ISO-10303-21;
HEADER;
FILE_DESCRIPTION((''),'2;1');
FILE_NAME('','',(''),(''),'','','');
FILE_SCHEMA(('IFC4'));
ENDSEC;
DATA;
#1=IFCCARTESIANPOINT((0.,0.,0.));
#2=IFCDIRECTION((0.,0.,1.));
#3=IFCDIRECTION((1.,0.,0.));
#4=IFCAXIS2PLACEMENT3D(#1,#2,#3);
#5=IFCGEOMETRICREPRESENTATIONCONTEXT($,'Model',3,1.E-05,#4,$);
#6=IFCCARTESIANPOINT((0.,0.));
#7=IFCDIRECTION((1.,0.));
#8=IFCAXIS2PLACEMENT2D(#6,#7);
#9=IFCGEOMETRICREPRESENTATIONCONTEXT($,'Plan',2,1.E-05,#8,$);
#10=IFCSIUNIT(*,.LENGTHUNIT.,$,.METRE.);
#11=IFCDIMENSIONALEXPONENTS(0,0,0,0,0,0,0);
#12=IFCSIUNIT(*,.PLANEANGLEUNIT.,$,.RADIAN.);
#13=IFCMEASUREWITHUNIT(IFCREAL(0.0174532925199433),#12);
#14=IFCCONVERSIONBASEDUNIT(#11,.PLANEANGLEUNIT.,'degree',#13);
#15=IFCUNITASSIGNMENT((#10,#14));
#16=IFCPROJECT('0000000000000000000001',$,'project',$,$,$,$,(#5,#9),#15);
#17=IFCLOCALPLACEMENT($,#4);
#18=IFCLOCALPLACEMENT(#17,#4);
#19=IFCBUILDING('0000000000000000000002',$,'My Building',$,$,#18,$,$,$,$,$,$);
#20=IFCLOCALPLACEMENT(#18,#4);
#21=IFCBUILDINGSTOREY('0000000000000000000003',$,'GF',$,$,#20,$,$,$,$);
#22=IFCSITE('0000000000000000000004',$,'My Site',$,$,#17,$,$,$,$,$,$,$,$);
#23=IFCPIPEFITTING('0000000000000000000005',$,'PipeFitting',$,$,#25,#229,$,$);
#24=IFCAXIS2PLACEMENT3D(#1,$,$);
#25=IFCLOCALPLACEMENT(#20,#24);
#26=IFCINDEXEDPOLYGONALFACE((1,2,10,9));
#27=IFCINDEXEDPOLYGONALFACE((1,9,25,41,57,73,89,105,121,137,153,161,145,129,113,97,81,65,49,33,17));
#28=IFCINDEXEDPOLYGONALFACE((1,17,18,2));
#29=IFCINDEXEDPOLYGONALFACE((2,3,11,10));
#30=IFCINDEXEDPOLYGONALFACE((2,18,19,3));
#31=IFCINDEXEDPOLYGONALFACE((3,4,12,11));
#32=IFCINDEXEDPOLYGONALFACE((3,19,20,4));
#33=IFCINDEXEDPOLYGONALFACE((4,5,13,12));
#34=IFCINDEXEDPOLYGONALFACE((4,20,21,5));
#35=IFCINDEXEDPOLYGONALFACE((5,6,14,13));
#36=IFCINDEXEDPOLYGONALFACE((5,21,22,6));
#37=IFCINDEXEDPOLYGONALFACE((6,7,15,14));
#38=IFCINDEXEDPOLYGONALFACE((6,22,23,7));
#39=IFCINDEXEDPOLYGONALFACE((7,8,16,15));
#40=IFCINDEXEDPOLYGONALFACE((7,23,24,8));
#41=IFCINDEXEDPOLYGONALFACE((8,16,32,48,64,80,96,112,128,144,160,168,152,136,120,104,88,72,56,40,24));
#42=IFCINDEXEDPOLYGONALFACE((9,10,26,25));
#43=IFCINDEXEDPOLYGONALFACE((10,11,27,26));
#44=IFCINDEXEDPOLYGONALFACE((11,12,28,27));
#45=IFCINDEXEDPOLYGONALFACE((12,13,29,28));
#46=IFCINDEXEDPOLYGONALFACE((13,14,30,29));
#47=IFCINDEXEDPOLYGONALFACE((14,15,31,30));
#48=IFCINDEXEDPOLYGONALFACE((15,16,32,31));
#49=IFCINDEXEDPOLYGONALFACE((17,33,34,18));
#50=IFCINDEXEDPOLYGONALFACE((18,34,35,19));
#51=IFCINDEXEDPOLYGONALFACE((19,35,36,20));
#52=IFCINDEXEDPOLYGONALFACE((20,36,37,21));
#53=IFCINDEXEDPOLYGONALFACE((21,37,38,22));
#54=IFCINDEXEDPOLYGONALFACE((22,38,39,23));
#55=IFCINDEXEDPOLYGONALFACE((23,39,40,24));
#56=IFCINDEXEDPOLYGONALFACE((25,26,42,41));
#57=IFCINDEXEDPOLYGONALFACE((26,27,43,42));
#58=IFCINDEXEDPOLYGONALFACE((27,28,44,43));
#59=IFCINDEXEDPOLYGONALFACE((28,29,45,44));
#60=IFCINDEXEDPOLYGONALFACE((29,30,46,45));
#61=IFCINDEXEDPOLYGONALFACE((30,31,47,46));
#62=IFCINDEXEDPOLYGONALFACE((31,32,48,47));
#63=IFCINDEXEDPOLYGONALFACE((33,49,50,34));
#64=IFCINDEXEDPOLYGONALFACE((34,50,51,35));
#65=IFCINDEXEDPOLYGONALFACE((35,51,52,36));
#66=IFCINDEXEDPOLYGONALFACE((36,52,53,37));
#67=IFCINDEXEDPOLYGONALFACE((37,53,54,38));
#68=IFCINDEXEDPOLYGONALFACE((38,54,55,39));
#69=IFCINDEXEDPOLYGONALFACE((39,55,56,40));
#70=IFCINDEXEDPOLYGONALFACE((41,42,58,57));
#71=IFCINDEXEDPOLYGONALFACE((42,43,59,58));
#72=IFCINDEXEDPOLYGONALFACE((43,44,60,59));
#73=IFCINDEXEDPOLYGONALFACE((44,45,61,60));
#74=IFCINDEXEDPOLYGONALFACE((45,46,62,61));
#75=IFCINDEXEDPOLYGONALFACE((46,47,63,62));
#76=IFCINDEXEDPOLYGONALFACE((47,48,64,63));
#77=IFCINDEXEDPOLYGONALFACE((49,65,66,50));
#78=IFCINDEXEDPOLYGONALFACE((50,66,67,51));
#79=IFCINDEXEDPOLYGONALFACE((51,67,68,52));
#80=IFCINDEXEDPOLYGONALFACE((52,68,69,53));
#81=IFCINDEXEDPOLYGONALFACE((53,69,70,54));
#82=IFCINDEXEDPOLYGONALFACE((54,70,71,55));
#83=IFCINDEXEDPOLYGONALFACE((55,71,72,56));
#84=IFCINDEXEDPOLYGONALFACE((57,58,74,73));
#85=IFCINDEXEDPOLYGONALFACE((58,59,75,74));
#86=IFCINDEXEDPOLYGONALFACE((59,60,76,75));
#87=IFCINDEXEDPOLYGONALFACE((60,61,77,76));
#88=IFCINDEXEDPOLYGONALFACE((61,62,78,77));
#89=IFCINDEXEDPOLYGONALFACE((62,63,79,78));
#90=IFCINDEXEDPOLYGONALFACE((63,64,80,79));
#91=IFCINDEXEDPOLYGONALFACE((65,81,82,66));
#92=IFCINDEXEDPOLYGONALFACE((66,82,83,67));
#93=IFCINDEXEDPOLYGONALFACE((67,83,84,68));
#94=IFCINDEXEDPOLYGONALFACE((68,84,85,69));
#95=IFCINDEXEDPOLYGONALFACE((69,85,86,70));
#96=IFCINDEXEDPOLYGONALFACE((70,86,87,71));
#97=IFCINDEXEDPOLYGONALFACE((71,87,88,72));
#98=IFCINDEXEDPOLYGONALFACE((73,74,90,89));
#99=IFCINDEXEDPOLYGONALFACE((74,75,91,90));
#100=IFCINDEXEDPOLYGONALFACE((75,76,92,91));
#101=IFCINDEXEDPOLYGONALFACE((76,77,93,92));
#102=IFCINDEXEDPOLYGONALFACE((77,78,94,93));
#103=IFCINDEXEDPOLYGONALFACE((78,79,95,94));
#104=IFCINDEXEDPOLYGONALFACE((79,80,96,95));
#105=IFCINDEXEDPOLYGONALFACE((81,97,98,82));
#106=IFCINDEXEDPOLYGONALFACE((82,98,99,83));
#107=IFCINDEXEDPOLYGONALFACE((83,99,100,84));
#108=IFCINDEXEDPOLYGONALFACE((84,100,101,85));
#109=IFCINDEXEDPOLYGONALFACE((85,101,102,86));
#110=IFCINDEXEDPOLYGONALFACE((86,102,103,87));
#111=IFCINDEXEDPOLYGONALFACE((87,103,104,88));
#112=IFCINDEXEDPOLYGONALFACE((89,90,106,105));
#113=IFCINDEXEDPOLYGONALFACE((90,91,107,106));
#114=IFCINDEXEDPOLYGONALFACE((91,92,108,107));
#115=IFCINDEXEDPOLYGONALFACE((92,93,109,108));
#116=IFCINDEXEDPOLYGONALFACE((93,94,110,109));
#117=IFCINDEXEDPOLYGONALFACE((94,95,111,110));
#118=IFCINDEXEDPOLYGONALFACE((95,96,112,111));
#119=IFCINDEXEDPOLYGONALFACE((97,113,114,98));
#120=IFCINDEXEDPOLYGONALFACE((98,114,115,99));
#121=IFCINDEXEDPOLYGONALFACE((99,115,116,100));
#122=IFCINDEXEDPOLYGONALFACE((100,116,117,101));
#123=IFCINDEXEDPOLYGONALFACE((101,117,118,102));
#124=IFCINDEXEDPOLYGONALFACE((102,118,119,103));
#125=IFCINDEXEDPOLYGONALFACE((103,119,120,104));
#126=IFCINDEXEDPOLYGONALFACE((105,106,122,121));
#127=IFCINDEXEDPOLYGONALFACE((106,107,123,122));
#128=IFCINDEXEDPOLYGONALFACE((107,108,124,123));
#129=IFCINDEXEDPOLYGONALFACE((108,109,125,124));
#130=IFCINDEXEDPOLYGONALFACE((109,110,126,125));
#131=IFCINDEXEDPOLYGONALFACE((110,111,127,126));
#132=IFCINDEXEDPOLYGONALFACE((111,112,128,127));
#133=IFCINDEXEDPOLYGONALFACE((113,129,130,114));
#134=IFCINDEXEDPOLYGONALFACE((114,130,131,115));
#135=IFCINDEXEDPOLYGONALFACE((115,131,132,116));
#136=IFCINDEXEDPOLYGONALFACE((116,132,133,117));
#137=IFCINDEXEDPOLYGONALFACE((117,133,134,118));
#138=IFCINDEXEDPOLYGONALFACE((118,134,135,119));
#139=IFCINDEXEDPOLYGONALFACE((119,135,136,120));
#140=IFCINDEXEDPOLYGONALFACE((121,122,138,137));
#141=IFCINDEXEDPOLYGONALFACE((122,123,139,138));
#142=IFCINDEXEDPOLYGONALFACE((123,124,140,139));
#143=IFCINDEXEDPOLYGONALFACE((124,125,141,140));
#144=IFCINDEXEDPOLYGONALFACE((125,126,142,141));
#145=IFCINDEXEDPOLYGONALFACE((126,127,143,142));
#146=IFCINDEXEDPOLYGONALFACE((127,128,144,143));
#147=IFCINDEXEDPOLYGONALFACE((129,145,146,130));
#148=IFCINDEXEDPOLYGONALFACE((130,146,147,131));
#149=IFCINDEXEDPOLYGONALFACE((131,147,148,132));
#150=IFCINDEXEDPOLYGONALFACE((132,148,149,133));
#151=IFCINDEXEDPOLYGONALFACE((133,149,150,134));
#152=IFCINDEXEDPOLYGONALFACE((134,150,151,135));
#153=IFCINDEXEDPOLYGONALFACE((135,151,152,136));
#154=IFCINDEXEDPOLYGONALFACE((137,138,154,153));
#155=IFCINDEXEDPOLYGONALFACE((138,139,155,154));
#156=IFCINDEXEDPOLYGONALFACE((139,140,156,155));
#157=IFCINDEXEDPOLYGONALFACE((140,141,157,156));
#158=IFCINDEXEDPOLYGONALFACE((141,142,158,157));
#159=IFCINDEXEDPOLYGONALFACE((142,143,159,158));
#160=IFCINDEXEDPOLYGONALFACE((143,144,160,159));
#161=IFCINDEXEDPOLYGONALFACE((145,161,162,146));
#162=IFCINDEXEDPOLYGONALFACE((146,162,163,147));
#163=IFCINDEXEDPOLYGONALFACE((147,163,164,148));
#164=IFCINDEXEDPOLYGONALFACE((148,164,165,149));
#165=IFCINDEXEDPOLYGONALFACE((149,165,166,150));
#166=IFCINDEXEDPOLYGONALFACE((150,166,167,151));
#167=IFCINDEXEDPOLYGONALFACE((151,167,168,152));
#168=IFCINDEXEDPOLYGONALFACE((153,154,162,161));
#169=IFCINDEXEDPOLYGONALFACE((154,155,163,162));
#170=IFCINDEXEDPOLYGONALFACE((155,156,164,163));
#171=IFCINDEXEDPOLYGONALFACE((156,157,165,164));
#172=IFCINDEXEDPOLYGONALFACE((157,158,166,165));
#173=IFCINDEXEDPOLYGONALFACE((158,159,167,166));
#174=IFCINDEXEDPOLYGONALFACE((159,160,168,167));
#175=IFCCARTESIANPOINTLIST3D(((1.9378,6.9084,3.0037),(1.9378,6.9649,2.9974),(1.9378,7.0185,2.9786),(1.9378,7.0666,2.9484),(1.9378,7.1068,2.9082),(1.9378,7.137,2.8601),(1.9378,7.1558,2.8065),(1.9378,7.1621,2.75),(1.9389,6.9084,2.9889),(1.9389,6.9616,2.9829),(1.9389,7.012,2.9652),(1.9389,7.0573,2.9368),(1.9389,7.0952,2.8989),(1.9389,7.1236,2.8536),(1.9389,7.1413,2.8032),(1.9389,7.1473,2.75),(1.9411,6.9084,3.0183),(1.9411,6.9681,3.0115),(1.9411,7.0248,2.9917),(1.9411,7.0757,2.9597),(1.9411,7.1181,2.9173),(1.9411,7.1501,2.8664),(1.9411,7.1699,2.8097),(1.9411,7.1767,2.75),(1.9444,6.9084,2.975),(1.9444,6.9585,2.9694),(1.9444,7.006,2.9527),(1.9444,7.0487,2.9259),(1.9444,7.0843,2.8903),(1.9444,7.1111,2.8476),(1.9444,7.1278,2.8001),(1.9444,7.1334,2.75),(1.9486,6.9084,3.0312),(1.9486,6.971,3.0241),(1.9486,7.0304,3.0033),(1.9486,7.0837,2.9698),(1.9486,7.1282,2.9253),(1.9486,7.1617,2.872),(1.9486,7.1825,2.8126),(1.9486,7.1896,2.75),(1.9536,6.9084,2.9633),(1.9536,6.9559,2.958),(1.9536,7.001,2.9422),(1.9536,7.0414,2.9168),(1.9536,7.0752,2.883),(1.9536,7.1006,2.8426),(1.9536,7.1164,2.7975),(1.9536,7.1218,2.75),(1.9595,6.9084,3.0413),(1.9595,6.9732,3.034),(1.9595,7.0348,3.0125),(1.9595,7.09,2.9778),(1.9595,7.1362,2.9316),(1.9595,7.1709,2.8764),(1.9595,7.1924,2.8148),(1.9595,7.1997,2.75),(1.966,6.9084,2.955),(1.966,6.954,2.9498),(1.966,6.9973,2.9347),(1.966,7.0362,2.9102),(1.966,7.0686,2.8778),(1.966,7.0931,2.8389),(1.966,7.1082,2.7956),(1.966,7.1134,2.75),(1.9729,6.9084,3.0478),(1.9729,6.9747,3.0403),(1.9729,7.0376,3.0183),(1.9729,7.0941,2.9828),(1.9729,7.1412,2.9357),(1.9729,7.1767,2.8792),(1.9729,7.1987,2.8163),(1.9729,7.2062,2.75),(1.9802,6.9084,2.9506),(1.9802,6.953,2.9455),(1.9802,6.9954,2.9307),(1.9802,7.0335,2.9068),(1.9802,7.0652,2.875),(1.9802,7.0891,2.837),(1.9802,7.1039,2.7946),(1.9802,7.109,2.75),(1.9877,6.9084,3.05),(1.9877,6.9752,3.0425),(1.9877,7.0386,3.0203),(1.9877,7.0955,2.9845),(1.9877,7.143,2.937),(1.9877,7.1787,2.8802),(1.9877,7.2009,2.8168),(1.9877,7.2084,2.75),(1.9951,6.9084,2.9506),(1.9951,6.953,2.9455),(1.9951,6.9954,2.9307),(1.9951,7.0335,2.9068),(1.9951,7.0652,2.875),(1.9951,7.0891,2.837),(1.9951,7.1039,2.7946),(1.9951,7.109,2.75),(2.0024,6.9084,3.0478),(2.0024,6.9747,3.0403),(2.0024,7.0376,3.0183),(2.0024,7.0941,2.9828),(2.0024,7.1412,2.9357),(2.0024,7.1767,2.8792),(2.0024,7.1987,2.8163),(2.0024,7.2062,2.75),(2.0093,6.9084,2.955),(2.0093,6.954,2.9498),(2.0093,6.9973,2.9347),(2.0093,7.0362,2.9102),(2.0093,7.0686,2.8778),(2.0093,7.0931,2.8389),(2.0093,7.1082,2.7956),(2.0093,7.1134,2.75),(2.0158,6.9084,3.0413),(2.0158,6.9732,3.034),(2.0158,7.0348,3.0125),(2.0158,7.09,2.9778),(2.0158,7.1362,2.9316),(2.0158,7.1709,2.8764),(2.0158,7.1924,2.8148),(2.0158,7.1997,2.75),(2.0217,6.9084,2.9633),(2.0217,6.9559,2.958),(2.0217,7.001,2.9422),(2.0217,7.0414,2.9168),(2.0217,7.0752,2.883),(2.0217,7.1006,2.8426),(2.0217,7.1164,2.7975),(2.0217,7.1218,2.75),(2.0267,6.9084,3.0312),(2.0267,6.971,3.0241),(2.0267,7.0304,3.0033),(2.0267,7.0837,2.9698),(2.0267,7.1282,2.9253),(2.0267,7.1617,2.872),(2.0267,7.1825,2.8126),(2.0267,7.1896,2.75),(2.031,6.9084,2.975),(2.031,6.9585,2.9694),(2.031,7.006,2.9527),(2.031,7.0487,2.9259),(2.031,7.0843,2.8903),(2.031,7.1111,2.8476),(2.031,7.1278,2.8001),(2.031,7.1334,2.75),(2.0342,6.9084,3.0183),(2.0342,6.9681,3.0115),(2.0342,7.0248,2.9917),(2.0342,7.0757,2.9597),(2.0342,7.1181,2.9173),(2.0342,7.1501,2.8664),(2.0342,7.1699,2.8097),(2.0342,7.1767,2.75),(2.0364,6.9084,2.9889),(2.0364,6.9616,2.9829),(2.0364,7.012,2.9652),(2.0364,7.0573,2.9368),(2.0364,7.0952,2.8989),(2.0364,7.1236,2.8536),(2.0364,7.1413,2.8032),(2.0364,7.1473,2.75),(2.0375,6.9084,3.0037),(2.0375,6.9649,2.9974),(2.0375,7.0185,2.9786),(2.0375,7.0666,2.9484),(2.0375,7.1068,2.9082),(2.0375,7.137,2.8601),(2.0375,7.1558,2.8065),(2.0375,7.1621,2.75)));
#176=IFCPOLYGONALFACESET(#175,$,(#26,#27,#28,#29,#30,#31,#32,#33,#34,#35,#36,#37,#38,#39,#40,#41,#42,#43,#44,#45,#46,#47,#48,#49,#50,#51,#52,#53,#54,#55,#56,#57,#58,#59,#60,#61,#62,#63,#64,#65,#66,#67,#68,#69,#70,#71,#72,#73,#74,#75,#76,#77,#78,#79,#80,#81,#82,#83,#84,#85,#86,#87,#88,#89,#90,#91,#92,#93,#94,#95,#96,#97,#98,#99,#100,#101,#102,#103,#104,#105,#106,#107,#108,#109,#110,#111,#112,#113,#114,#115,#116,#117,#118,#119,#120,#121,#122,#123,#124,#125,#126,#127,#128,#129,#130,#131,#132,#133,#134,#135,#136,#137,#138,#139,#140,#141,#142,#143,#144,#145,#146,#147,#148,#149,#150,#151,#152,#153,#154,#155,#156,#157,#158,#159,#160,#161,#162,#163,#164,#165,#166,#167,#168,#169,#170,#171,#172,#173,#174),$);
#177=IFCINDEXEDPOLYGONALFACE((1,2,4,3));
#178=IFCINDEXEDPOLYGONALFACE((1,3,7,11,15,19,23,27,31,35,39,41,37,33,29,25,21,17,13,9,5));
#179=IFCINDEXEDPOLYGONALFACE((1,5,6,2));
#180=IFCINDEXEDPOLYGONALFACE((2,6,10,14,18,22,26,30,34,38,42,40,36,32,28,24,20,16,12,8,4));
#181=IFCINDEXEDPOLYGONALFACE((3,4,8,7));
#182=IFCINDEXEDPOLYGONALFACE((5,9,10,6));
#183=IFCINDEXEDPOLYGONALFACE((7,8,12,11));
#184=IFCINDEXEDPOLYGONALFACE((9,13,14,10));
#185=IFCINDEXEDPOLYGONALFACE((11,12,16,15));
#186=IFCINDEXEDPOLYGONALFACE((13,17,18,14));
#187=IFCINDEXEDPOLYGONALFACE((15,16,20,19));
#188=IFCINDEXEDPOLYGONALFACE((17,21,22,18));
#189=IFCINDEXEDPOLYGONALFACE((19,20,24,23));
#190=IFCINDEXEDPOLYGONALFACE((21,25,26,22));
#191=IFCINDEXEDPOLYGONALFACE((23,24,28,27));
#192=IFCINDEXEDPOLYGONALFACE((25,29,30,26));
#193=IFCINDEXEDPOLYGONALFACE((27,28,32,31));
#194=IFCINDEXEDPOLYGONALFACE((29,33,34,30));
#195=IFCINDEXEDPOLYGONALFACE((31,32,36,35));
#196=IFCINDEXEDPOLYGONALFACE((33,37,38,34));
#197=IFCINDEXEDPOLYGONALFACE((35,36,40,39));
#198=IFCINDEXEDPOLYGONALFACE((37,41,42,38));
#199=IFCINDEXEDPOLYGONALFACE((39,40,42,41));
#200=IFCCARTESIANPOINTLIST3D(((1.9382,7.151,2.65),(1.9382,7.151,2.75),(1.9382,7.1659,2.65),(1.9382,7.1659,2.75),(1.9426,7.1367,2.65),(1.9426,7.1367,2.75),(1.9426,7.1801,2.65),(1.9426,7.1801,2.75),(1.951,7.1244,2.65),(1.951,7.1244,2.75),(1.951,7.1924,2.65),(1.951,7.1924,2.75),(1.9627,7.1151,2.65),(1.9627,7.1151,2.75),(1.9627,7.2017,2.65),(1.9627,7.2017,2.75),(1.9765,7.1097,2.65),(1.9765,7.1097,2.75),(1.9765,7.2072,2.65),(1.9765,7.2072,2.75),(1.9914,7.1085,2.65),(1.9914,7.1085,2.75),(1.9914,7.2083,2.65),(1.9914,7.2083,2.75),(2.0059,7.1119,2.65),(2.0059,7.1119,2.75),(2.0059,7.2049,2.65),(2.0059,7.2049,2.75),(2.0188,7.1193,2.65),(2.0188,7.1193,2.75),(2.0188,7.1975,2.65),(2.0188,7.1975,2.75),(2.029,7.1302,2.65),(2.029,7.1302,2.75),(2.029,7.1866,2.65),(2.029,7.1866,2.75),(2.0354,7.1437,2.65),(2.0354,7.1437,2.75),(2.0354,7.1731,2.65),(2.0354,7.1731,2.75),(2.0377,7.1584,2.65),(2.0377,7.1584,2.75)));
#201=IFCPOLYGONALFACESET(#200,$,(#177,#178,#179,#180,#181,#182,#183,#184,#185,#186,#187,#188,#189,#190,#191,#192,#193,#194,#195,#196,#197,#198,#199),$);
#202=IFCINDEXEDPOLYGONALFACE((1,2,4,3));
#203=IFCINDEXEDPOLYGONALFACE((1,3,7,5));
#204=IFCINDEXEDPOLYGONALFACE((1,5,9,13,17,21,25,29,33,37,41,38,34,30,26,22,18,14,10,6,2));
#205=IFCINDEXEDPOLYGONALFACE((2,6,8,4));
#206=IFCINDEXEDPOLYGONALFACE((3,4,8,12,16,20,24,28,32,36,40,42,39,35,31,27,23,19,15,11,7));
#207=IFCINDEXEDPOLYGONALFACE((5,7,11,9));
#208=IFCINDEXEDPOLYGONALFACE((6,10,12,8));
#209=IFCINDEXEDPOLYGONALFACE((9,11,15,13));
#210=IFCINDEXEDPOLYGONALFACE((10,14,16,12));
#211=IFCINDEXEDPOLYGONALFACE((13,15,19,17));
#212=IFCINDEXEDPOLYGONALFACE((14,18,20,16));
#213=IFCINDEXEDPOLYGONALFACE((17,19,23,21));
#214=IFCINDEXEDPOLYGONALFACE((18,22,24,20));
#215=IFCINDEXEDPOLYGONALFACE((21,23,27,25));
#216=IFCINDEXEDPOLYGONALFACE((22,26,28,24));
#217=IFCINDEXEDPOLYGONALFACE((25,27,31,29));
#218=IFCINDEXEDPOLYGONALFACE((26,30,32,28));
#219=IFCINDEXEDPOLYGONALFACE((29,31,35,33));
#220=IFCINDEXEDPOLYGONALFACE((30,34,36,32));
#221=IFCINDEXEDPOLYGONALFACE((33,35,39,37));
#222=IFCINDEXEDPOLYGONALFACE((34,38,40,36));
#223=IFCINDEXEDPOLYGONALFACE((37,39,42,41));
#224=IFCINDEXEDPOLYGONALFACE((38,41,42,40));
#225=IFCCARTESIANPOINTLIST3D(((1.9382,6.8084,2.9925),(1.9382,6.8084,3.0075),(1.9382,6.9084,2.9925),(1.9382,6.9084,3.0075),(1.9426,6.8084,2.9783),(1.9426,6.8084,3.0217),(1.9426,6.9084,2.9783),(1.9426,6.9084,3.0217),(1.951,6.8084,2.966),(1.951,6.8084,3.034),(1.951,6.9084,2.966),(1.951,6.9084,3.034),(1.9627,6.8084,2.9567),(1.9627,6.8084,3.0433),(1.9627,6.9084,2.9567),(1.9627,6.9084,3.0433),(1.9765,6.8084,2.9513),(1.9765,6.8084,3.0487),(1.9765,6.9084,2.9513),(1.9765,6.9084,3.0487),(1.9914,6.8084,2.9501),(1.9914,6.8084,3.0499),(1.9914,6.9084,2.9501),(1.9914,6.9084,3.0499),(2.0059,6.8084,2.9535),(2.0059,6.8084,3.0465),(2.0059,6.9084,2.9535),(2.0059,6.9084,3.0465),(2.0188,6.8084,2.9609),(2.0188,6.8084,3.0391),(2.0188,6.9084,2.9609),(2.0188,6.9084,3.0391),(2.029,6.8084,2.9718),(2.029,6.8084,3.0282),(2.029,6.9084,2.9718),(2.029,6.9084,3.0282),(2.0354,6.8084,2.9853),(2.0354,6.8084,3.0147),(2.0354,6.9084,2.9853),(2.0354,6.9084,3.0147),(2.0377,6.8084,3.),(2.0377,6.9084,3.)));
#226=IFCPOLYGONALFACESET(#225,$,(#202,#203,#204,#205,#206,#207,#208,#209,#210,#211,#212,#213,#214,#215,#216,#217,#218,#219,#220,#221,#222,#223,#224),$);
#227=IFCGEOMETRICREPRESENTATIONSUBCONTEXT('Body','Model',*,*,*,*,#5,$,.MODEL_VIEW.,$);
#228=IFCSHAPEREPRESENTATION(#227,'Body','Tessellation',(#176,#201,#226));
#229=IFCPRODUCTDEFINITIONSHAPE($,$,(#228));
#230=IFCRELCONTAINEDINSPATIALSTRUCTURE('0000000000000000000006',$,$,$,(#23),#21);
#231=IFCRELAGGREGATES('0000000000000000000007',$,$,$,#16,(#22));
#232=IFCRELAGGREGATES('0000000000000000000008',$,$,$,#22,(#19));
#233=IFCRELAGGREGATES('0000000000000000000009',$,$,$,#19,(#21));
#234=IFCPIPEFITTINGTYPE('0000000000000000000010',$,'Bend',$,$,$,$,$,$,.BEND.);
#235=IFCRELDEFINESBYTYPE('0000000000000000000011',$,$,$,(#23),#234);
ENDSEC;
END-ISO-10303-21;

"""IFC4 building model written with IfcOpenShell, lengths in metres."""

from ifc_helpers import new_model, entity, si_unit, converted_unit, frame, origin_with_axes, origin_2d_with_axis, place, context, subcontext, project, spatial, circle, extrude, source, transform, mapped, type_object, type_shapes, element, save


model = new_model("IFC4")

# Units and contexts
model_context = context("Model", 3, precision=1e-05, world=origin_with_axes())
plan_context = context("Plan", 2, precision=1e-05, world=origin_2d_with_axis())
body_context_1 = subcontext(model_context, "Body", "Model", "MODEL_VIEW")
ifc_project = project(units=[si_unit("LENGTHUNIT", "METRE"), converted_unit("PLANEANGLEUNIT", "degree", entity("IfcReal", 0.0174532925199433), si_unit("PLANEANGLEUNIT", "RADIAN"), dimensions=[0, 0, 0, 0, 0, 0, 0])], contexts=[model_context, plan_context])

# Site, building, storey
site_placement = place(None, origin_with_axes())
site = spatial("IfcSite", under=ifc_project, at=site_placement, Name="My Site")
building_placement = place(site_placement, origin_with_axes())
building = spatial("IfcBuilding", under=site, at=building_placement, Name="My Building")
storey_placement = place(building_placement, origin_with_axes())
storey = spatial("IfcBuildingStorey", under=building, at=storey_placement, Name="GF")

# Pipe fitting
pipe_fitting_type = type_object("IfcPipeFittingType", Name="Bend", PredefinedType="BEND")
shared_shape_1 = source(origin_with_axes(), body_context_1, "Body", "SolidModel", [
    entity("IfcSweptDiskSolid", entity("IfcIndexedPolyCurve", entity("IfcCartesianPointList3D", [[0.0, 0.0, -0.1], [0.0, 0.0732, -0.2768], [0.0, 0.25, -0.35]]), [entity("IfcArcIndex", [1, 2, 3])]), 0.05),
    extrude(circle(Radius=0.05), origin_with_axes(), (0.0, 0.0, -1.0), 0.1),
    extrude(circle(Radius=0.05), frame((0.0, 0.25, -0.35), z_axis=(0.0, 1.0, 0.0), x_axis=(1.0, 0.0, 0.0)), (0.0, 0.0, 1.0), 0.1),
])
type_shapes(pipe_fitting_type, [shared_shape_1])
for number, where, z_axis, x_axis, name in (
    (1, (1.9877, 7.1584, 2.65), (0.0, 0.0, -1.0), (1.0, 0.0, 0.0), "PipeFitting"),
):
    element("IfcPipeFitting", number, at=place(storey_placement, frame(where, z_axis=z_axis, x_axis=x_axis)), inside=storey, type_object=pipe_fitting_type, Name=name, context=body_context_1, shape_type="MappedRepresentation", body=[
        mapped(shared_shape_1, transform((0.0, 0.0, 0.0), x_axis=(1.0, 0.0, 0.0), y_axis=(0.0, 1.0, 0.0), z_axis=(0.0, 0.0, 1.0), scale=1.0)),
    ])

save(model, "model.ifc")
